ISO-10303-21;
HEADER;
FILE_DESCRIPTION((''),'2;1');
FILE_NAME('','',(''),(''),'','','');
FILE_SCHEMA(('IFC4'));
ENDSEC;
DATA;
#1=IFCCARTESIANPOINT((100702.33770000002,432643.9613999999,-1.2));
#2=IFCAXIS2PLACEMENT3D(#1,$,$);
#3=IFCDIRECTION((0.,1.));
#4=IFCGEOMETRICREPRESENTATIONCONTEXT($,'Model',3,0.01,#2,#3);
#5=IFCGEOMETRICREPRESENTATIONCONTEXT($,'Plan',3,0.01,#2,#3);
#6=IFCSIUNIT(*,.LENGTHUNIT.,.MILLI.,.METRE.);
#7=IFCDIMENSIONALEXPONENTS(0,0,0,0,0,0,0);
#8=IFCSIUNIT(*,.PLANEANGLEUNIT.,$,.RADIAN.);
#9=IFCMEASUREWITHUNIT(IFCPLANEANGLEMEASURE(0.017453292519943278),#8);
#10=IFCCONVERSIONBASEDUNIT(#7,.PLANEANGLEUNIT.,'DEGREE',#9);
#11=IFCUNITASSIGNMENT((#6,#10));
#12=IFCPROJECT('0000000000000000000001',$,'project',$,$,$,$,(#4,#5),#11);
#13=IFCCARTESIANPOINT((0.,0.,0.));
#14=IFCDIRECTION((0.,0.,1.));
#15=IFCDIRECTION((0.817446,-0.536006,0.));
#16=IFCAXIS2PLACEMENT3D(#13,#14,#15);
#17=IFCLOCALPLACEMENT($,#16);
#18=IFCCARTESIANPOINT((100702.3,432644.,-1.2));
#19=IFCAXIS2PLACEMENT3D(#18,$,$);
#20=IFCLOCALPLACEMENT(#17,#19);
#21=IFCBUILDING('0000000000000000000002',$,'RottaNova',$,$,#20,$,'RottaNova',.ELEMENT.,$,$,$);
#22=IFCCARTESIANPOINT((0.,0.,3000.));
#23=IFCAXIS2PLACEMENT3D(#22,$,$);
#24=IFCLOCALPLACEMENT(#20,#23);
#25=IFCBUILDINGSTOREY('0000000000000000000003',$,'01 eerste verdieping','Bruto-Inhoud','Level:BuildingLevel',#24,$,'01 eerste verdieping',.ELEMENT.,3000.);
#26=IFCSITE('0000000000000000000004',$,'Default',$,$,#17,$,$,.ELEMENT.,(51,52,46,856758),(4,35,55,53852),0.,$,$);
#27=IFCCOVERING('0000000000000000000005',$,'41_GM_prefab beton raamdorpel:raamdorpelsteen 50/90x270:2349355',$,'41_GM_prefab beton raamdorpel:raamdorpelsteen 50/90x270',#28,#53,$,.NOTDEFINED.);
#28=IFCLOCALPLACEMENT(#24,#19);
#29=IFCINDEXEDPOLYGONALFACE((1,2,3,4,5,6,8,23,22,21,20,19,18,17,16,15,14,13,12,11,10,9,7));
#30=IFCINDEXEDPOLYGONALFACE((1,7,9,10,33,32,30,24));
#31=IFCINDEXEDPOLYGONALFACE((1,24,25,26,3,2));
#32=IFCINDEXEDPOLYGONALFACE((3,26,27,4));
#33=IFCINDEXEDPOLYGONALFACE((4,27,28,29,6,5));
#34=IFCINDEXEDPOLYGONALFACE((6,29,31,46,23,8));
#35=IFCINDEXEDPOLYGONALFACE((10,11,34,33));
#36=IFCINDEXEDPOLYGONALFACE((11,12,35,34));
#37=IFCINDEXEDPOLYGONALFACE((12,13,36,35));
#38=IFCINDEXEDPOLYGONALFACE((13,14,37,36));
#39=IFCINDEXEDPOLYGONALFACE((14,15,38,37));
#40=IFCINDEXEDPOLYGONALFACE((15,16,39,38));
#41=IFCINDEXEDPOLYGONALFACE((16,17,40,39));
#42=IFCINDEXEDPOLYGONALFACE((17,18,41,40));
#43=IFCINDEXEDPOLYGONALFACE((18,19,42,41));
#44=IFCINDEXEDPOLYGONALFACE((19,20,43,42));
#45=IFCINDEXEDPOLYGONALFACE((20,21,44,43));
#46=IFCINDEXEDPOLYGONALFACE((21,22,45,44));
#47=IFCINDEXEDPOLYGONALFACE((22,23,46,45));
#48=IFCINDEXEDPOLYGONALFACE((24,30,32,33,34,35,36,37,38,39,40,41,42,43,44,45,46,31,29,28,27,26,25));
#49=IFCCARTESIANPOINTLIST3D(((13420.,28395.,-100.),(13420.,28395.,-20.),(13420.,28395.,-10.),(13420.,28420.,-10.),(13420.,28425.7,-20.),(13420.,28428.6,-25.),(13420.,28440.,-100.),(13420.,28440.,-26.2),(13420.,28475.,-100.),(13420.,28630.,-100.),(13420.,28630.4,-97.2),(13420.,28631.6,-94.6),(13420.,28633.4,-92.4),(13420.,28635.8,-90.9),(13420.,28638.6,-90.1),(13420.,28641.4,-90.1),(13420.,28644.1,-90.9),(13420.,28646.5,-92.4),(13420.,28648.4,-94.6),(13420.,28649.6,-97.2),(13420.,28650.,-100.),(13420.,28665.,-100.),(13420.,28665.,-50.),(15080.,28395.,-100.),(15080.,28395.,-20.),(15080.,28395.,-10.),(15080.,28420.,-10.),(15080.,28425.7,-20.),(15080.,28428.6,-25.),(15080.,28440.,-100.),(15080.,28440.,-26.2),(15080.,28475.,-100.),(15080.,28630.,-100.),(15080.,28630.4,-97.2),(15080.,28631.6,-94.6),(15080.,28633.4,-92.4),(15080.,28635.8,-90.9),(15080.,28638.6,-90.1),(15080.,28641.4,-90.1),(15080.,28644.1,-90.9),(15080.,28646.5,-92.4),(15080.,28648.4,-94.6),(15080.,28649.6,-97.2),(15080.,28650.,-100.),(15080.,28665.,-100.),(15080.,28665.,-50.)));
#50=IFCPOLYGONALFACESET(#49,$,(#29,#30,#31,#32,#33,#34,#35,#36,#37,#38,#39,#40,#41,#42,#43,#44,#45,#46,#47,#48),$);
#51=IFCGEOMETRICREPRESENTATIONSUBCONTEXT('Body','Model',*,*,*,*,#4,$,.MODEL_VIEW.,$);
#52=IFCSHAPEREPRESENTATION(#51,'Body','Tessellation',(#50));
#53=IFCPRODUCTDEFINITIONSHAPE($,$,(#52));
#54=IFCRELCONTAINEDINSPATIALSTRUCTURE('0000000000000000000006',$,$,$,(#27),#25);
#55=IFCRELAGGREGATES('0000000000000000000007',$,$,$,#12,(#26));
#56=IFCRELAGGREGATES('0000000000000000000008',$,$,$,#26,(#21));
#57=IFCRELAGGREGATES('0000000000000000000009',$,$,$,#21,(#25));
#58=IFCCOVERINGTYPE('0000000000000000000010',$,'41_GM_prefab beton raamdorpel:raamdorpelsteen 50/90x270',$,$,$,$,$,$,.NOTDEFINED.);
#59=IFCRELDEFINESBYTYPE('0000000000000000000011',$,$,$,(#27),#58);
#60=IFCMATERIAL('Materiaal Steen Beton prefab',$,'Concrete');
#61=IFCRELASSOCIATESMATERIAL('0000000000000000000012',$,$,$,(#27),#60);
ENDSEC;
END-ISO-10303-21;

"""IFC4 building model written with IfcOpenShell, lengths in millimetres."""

from ifc_helpers import new_model, entity, si_unit, converted_unit, direction, frame, place, context, subcontext, project, spatial, line, arc, indexed_curve, outline, extrude, material, type_object, element, save


model = new_model("IFC4")

# Units and contexts
model_context = context("Model", 3, precision=0.01, world=frame((100702.33770000002, 432643.9613999999, -1.2)), true_north=direction((0.0, 1.0)))
plan_context = context("Plan", 3, precision=0.01, world=frame((100702.33770000002, 432643.9613999999, -1.2)), true_north=direction((0.0, 1.0)))
body_context = subcontext(model_context, "Body", "Model", "MODEL_VIEW")
ifc_project = project(units=[si_unit("LENGTHUNIT", "METRE", prefix="MILLI"), converted_unit("PLANEANGLEUNIT", "DEGREE", entity("IfcPlaneAngleMeasure", 0.017453292519943278), si_unit("PLANEANGLEUNIT", "RADIAN"), dimensions=[0, 0, 0, 0, 0, 0, 0])], contexts=[model_context, plan_context])

# Site, building, storey
site_placement = place(None, frame((0.0, 0.0, 0.0), z_axis=(0.0, 0.0, 1.0), x_axis=(0.817446, -0.536006, 0.0)))
site = spatial("IfcSite", under=ifc_project, at=site_placement, Name="Default", CompositionType="ELEMENT", RefLatitude=(51, 52, 46, 856758), RefLongitude=(4, 35, 55, 53852), RefElevation=0.0)
building_placement = place(site_placement, frame((100702.3, 432644.0, -1.2)))
building = spatial("IfcBuilding", under=site, at=building_placement, Name="RottaNova", LongName="RottaNova", CompositionType="ELEMENT")
storey_placement = place(building_placement, frame((0.0, 0.0, 3000.0)))
storey = spatial("IfcBuildingStorey", under=building, at=storey_placement, Name="01 eerste verdieping", Description="Bruto-Inhoud", ObjectType="Level:BuildingLevel", LongName="01 eerste verdieping", CompositionType="ELEMENT", Elevation=3000.0)

# Shared definitions
ifc_material_1 = material(Name="Materiaal Steen Beton prefab", Category="Concrete")

# Covering
covering_type = type_object("IfcCoveringType", Name="41_GM_prefab beton raamdorpel:raamdorpelsteen 50/90x270", PredefinedType="NOTDEFINED")
covering_1_placement = place(storey_placement, frame((100702.3, 432644.0, -1.2)))
element("IfcCovering", 1, at=covering_1_placement, inside=storey, type_object=covering_type, material=ifc_material_1, Name="41_GM_prefab beton raamdorpel:raamdorpelsteen 50/90x270:2349355", ObjectType="41_GM_prefab beton raamdorpel:raamdorpelsteen 50/90x270", PredefinedType="NOTDEFINED", context=body_context, shape_type="SweptSolid", body=[
    extrude(outline(indexed_curve([(74.2, -48.6), (99.2, -48.6), (99.2, -38.6), (99.2, 41.4), (54.2, 41.4), (19.2, 41.4), (-135.8, 41.4), (-145.8, 31.4), (-155.8, 41.4), (-170.8, 41.4), (-170.8, -8.6), (54.2, -32.4), (65.5, -33.6), (68.4, -38.6)], segments=[line(1, 2, 3, 4, 5, 6, 7), arc(7, 8, 9), line(9, 10, 11, 12, 13, 14, 1)], self_intersect=False)), frame((13420.0, 28494.2, -58.6), z_axis=(1.0, 0.0, 0.0), x_axis=(0.0, -1.0, 0.0)), (0.0, 0.0, 1.0), 1660.0),
])

save(model, "model.ifc")
